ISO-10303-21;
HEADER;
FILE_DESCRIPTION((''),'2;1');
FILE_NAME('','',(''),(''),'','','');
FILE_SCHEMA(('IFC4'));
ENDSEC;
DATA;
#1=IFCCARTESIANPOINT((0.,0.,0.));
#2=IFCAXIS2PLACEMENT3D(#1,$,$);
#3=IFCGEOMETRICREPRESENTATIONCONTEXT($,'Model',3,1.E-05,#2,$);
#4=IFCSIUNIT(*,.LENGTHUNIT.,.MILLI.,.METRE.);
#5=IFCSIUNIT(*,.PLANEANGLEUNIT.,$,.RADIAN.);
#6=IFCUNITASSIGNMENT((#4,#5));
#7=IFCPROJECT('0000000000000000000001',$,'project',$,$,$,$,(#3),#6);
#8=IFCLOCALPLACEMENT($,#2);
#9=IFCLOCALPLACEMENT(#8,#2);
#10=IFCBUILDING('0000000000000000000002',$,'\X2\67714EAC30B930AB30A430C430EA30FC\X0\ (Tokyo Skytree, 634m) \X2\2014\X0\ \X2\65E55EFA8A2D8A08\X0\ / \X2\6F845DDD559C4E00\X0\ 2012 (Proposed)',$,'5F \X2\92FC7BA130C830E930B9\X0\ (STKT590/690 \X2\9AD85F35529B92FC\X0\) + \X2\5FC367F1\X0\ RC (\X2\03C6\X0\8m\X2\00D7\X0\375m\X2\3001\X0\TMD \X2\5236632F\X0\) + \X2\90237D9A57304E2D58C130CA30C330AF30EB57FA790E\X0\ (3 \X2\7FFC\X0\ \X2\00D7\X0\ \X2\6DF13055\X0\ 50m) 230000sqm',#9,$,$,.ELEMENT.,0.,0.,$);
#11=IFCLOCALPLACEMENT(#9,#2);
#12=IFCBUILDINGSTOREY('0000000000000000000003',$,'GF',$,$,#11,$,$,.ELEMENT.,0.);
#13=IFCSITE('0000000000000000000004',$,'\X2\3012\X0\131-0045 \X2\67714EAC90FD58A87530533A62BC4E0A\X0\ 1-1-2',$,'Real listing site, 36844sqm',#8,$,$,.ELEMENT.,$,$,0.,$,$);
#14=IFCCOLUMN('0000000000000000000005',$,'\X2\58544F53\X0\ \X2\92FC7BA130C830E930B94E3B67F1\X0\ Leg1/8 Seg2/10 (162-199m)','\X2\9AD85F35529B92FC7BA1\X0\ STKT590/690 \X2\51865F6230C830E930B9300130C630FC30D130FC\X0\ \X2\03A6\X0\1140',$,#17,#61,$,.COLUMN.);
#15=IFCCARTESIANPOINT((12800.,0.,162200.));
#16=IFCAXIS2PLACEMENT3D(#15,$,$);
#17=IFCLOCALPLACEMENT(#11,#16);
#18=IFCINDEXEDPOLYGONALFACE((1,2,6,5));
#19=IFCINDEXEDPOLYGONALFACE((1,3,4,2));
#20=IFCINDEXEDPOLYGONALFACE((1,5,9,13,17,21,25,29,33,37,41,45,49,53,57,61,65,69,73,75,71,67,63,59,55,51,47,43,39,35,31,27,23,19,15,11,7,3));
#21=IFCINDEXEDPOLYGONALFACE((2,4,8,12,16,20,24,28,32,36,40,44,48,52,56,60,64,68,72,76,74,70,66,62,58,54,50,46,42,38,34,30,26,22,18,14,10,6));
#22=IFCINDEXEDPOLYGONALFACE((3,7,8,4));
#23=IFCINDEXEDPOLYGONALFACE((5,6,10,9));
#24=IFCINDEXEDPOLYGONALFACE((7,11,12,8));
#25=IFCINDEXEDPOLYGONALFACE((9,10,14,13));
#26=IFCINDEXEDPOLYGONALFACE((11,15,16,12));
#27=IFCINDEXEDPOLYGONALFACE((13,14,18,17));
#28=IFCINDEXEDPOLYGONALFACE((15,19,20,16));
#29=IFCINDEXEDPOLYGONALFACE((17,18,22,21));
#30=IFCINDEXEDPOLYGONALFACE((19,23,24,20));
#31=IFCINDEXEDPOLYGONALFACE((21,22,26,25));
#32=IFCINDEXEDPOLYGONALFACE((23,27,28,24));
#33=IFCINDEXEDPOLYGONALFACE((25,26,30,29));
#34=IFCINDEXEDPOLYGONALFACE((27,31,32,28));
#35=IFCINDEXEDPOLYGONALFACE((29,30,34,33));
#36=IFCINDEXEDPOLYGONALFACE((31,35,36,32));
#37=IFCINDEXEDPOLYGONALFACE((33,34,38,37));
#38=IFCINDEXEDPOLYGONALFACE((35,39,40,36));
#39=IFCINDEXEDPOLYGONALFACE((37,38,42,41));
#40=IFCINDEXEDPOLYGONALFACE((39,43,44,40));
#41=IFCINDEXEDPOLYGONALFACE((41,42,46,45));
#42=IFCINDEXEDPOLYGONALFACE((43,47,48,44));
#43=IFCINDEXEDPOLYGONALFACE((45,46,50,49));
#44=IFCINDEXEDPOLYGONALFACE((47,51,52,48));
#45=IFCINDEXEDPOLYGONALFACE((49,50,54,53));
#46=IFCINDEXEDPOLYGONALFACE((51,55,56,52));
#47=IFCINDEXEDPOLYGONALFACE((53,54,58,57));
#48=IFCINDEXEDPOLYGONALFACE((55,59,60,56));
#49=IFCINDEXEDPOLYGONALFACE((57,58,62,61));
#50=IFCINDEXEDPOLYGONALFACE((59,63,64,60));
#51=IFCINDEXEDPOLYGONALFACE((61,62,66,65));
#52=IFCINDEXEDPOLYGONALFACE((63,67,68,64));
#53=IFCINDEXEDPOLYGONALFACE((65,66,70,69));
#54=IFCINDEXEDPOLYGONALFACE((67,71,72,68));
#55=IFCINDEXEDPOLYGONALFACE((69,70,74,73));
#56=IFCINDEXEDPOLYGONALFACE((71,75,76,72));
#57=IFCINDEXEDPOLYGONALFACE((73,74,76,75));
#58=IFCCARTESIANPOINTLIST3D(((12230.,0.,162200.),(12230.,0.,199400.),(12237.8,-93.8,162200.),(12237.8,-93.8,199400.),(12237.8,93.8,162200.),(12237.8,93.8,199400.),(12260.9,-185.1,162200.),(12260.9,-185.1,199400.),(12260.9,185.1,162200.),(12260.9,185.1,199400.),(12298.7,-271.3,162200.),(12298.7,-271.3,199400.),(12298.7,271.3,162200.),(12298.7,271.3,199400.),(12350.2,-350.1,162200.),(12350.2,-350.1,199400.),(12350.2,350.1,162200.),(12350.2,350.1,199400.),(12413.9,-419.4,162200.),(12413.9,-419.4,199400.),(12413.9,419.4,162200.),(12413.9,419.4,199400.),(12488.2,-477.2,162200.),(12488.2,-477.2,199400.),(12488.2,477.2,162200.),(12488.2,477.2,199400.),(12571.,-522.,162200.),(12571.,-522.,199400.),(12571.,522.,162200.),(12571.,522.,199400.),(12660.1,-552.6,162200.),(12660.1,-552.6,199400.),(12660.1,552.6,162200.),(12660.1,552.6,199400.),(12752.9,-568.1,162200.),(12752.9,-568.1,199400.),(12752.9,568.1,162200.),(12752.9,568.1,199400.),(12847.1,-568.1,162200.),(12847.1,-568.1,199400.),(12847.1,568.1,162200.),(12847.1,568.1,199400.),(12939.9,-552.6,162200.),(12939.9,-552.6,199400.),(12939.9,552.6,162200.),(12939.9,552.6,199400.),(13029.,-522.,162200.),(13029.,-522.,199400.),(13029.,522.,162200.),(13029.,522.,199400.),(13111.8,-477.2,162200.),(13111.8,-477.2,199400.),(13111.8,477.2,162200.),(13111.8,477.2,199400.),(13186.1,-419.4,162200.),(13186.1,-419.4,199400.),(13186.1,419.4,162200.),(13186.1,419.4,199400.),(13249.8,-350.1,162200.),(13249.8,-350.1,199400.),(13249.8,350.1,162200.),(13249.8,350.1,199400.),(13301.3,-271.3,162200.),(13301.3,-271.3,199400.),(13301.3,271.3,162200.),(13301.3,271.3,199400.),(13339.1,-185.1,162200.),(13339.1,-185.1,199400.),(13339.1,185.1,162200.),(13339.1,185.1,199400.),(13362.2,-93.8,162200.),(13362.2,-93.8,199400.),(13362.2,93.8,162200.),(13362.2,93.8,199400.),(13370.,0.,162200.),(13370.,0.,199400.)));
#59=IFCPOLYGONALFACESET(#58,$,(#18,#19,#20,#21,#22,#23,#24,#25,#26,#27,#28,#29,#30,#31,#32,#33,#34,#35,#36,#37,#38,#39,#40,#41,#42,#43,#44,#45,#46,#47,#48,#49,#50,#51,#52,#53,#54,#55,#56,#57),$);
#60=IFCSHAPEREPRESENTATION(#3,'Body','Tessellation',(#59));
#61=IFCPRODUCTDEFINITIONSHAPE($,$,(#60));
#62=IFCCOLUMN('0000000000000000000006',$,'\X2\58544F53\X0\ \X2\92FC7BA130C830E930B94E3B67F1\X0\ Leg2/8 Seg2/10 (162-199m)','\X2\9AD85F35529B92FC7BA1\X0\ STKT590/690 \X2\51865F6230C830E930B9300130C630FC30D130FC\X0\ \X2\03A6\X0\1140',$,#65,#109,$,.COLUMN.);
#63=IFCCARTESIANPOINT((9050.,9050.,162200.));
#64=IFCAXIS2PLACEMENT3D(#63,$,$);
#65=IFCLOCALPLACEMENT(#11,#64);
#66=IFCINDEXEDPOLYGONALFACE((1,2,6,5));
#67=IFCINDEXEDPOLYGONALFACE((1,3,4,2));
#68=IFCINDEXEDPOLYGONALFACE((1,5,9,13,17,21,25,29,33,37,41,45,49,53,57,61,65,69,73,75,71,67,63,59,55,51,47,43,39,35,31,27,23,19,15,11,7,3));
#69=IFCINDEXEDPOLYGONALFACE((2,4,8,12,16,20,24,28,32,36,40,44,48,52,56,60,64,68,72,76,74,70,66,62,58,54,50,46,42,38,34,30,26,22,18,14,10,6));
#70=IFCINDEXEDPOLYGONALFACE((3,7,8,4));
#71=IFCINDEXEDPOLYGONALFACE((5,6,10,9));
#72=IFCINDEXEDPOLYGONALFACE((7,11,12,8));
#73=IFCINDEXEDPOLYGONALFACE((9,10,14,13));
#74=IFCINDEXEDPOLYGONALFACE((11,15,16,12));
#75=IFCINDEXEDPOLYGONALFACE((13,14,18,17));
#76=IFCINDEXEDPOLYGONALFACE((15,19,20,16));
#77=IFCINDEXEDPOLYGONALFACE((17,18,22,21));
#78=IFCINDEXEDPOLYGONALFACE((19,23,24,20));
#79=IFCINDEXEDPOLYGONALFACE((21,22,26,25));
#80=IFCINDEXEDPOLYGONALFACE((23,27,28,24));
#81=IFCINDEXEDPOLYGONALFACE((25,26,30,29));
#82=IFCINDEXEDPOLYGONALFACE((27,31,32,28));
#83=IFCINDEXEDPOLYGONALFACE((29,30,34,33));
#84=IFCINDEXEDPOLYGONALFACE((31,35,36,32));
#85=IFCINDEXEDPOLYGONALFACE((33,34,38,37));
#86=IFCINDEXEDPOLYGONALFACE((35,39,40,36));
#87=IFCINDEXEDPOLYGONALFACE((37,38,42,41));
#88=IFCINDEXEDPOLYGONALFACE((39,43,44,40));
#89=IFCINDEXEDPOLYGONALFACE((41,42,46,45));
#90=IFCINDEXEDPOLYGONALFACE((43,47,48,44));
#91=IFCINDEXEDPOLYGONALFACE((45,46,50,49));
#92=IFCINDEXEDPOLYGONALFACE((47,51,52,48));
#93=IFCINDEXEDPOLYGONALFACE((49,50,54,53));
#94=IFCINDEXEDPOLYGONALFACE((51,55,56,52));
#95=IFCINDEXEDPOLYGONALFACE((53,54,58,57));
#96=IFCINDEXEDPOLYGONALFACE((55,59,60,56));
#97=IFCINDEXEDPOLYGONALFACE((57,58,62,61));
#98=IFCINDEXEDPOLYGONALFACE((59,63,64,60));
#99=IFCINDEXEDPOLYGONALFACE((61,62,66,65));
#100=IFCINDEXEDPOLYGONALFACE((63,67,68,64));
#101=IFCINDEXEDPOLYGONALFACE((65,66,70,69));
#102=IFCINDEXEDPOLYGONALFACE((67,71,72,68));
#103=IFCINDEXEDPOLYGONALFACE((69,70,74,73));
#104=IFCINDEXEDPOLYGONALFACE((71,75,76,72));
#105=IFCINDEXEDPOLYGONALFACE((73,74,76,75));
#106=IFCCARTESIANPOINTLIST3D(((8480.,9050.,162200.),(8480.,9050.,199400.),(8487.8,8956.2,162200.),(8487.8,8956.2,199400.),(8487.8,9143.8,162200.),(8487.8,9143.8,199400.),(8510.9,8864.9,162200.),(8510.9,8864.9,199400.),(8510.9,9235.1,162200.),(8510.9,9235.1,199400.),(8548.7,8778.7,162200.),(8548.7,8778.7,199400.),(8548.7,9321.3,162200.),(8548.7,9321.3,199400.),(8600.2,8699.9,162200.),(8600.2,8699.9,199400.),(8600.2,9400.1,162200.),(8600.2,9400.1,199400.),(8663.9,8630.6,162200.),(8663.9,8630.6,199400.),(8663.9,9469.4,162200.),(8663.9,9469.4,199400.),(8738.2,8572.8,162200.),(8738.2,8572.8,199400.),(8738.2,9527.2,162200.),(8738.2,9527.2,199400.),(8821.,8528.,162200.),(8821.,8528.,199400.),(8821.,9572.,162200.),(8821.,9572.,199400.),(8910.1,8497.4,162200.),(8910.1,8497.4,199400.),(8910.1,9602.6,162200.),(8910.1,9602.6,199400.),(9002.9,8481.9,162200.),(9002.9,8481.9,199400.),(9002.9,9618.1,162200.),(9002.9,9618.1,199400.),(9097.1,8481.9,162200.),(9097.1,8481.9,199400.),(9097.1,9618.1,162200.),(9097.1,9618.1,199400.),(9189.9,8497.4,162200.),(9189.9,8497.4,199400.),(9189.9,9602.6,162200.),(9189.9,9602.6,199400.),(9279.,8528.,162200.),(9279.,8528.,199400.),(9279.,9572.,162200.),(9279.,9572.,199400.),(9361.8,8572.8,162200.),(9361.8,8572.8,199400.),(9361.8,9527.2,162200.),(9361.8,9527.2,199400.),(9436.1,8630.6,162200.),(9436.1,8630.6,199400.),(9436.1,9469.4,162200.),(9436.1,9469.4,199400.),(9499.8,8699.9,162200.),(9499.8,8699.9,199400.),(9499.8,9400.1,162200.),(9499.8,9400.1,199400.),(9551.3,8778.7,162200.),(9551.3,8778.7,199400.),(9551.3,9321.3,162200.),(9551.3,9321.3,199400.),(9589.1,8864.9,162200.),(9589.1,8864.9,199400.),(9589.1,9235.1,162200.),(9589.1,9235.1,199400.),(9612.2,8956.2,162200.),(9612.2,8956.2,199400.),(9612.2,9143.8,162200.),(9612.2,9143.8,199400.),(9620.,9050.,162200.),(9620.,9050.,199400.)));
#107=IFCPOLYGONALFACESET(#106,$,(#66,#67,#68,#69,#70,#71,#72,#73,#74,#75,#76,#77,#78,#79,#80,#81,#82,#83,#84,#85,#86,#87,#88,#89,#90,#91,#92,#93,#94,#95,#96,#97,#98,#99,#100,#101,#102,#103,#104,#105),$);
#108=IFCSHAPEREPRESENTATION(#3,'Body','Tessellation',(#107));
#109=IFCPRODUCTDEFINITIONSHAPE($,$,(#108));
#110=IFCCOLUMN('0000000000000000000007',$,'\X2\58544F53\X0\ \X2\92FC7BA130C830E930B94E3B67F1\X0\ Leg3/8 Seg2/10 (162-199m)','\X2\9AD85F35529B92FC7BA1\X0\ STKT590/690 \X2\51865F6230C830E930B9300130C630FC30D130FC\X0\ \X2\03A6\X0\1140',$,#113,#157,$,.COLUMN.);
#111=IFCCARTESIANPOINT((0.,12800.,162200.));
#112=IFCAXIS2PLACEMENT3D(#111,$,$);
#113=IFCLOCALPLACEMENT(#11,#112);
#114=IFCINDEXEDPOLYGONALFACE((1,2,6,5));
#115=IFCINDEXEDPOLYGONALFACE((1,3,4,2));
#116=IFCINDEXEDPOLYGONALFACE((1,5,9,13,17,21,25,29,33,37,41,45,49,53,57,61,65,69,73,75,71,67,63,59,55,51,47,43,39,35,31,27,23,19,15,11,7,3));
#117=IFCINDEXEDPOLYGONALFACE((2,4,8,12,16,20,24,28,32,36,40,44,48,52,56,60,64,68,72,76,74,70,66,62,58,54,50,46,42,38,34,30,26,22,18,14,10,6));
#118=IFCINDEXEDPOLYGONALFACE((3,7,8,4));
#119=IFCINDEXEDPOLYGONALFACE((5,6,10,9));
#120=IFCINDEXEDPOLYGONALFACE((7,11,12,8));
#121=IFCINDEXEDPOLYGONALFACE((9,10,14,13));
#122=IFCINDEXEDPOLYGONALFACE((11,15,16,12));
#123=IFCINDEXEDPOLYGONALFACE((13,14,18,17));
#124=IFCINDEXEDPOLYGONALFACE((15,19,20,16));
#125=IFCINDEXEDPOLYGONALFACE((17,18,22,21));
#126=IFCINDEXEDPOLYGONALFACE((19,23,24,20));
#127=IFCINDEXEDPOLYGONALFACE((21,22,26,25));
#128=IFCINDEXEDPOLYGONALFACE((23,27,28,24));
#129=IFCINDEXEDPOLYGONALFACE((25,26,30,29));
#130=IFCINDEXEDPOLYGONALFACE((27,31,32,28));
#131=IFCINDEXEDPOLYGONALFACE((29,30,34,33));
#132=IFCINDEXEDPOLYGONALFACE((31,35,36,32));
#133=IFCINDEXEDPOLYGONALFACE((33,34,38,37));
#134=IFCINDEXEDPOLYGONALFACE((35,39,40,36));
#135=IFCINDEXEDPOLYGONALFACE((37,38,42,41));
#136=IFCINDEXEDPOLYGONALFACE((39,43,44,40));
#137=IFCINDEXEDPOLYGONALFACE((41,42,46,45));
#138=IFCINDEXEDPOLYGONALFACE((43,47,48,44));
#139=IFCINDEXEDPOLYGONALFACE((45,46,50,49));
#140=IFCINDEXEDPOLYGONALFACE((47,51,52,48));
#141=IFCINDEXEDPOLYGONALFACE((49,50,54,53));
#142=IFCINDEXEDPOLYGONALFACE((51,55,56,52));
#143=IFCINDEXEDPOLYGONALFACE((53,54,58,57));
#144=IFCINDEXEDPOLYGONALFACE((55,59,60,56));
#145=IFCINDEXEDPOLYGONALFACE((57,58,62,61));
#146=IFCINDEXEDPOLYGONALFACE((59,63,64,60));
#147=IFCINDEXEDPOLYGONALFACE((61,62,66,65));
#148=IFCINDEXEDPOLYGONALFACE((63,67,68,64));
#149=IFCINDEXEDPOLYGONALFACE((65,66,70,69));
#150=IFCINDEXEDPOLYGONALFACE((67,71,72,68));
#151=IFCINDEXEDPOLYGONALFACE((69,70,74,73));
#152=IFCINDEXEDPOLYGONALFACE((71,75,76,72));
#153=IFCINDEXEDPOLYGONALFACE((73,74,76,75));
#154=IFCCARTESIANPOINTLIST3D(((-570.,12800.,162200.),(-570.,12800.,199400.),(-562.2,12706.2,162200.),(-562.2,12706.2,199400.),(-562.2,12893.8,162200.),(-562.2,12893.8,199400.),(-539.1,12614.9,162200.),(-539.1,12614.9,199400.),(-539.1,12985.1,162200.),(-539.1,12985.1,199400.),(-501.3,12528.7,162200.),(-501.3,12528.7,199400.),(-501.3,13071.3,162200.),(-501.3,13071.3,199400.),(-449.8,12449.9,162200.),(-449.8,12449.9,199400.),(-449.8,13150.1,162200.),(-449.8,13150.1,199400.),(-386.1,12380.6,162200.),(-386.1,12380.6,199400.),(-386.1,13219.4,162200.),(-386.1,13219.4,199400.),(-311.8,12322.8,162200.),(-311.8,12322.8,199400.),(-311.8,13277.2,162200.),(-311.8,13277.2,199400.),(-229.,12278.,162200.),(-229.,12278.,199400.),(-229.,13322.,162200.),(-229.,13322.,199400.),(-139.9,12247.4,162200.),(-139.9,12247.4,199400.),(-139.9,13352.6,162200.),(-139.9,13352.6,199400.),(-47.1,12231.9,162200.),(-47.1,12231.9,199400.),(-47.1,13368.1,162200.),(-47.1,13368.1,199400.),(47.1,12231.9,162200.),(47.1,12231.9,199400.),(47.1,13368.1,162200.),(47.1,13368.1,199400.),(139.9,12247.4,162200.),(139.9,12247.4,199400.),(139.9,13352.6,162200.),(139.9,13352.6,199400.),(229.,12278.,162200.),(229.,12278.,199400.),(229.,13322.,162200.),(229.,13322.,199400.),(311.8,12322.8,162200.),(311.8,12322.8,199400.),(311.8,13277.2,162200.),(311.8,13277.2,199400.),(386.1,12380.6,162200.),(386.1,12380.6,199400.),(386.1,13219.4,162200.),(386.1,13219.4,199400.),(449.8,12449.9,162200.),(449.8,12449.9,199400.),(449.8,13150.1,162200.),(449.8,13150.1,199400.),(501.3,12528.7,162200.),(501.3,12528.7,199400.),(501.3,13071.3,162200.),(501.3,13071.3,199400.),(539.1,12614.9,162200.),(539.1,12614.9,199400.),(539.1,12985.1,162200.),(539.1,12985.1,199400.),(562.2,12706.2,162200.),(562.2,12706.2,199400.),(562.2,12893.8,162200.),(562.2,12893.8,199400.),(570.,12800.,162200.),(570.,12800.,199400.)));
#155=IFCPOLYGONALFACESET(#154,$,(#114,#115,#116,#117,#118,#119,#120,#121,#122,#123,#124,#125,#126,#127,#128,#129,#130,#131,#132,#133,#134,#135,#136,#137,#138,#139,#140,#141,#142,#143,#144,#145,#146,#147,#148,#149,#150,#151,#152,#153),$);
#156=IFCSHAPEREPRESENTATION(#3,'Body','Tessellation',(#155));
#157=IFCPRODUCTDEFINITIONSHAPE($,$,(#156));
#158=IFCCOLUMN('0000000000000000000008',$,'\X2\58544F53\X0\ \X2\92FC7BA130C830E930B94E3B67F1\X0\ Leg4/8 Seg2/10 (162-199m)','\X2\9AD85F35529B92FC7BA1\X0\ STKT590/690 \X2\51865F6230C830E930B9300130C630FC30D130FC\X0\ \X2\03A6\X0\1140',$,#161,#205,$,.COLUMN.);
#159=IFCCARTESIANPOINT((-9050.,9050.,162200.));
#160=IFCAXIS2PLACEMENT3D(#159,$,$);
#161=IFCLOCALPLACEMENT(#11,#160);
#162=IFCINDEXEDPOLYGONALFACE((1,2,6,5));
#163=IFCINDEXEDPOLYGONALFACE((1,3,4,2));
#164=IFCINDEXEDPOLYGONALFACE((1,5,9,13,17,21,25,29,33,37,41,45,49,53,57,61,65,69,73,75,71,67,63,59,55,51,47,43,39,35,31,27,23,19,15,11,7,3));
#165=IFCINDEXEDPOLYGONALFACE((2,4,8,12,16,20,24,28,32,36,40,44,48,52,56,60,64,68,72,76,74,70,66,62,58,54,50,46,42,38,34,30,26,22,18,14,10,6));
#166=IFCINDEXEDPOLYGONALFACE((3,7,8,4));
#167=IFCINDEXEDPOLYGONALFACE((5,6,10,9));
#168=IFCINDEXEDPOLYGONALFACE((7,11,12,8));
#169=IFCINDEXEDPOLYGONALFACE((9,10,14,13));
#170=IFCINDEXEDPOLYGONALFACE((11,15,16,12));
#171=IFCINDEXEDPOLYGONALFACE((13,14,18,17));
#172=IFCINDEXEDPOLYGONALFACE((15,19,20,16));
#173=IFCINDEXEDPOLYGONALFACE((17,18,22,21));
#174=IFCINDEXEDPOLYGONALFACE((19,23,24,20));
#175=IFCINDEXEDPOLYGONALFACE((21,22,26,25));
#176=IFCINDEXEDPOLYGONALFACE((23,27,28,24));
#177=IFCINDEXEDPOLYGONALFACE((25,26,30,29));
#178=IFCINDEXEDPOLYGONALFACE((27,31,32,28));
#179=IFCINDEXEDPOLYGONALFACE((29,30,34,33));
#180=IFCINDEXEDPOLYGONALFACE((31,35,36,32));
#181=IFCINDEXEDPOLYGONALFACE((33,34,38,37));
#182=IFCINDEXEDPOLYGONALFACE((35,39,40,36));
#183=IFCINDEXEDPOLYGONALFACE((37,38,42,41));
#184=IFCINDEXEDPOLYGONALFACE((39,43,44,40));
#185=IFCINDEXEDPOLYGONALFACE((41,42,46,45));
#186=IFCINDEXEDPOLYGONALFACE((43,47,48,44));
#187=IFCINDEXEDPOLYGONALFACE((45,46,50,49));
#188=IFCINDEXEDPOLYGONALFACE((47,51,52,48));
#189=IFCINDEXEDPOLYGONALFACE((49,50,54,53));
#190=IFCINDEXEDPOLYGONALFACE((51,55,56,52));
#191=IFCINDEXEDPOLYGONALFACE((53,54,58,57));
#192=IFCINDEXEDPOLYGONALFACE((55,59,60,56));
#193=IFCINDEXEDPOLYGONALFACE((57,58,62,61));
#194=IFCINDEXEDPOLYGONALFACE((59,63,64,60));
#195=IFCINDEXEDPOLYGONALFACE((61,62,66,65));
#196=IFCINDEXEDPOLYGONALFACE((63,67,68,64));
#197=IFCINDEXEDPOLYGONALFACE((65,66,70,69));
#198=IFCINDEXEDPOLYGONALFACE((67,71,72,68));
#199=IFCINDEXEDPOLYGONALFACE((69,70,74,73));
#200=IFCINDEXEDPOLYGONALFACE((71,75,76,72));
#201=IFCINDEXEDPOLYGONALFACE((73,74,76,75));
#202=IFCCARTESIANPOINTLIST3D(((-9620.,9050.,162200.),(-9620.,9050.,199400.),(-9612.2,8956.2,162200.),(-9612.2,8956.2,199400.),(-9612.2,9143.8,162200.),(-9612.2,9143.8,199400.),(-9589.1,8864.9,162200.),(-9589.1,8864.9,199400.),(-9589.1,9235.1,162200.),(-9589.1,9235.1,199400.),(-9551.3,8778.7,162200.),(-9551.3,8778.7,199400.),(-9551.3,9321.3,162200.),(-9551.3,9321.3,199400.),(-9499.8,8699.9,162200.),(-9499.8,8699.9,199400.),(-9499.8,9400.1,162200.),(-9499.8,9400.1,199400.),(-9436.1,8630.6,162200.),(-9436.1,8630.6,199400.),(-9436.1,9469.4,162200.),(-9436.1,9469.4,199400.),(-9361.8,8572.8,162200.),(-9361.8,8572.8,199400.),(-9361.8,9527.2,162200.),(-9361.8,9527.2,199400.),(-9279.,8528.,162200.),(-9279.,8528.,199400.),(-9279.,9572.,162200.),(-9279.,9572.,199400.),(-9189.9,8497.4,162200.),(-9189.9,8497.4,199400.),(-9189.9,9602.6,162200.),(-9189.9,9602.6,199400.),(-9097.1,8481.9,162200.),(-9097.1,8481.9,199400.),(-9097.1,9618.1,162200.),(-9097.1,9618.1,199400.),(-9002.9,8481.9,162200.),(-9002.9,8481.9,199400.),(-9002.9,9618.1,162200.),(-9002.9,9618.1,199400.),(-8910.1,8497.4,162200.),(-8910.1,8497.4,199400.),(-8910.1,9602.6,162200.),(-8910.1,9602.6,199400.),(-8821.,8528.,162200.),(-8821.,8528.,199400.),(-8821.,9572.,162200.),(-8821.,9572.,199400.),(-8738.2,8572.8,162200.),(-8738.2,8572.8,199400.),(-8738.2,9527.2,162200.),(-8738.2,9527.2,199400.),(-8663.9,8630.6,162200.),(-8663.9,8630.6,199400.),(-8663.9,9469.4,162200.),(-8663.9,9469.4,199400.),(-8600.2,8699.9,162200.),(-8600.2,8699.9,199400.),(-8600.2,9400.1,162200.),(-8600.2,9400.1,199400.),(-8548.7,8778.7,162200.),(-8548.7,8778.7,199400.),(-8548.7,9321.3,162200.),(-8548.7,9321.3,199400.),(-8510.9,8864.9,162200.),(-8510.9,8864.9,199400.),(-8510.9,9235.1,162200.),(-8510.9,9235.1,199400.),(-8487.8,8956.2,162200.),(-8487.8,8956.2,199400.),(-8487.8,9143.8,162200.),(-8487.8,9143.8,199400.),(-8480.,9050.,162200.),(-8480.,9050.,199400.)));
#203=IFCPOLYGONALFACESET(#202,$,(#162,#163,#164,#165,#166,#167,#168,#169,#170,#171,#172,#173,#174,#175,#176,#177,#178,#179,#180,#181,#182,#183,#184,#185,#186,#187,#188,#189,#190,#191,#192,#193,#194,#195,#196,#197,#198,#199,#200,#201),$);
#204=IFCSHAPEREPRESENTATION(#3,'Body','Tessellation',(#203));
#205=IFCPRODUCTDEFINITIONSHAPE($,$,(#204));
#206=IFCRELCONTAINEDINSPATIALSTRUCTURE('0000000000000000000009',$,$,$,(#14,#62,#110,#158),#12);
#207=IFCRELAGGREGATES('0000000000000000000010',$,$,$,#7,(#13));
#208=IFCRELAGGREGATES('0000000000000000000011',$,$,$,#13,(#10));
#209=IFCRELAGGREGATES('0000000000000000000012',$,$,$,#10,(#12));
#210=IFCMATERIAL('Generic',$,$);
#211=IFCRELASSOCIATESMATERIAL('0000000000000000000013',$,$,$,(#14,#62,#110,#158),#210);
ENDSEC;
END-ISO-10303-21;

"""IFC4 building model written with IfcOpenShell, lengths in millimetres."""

from ifc_helpers import new_model, si_unit, frame, origin, origin_2d, place, context, project, spatial, circle, extrude, material, element, save


model = new_model("IFC4")

# Units and contexts
model_context = context("Model", 3, precision=1e-05, world=origin())
ifc_project = project(units=[si_unit("LENGTHUNIT", "METRE", prefix="MILLI"), si_unit("PLANEANGLEUNIT", "RADIAN")], contexts=[model_context])

# Site, building, storey
site_placement = place(None, origin())
site = spatial("IfcSite", under=ifc_project, at=site_placement, Name="〒131-0045 東京都墨田区押上 1-1-2", ObjectType="Real listing site, 36844sqm", CompositionType="ELEMENT", RefElevation=0.0)
building_placement = place(site_placement, origin())
building = spatial("IfcBuilding", under=site, at=building_placement, Name="東京スカイツリー (Tokyo Skytree, 634m) — 日建設計 / 澄川喜一 2012 (Proposed)", ObjectType="5F 鋼管トラス (STKT590/690 高張力鋼) + 心柱 RC (φ8m×375m、TMD 制振) + 連続地中壁ナックル基礎 (3 翼 × 深さ 50m) 230000sqm", CompositionType="ELEMENT", ElevationOfRefHeight=0.0, ElevationOfTerrain=0.0)
storey_placement = place(building_placement, origin())
storey = spatial("IfcBuildingStorey", under=building, at=storey_placement, Name="GF", CompositionType="ELEMENT", Elevation=0.0)

# Columns
ifc_material = material(Name="Generic")
column_1_placement = place(storey_placement, frame((12800.0, 0.0, 162200.0)))
element("IfcColumn", 1, at=column_1_placement, inside=storey, material=ifc_material, Name="塔体 鋼管トラス主柱 Leg1/8 Seg2/10 (162-199m)", Description="高張力鋼管 STKT590/690 円形トラス、テーパー Φ1140", PredefinedType="COLUMN", context=model_context, shape_type="SweptSolid", body=[
    extrude(circle(Radius=570.0, at=origin_2d()), frame((12800.0, 0.0, 162200.0)), (0.0, 0.0, 1.0), 37200.0),
])
column_2_placement = place(storey_placement, frame((9050.0, 9050.0, 162200.0)))
element("IfcColumn", 2, at=column_2_placement, inside=storey, material=ifc_material, Name="塔体 鋼管トラス主柱 Leg2/8 Seg2/10 (162-199m)", Description="高張力鋼管 STKT590/690 円形トラス、テーパー Φ1140", PredefinedType="COLUMN", context=model_context, shape_type="SweptSolid", body=[
    extrude(circle(Radius=570.0, at=origin_2d()), frame((9050.0, 9050.0, 162200.0)), (0.0, 0.0, 1.0), 37200.0),
])
column_3_placement = place(storey_placement, frame((0.0, 12800.0, 162200.0)))
element("IfcColumn", 3, at=column_3_placement, inside=storey, material=ifc_material, Name="塔体 鋼管トラス主柱 Leg3/8 Seg2/10 (162-199m)", Description="高張力鋼管 STKT590/690 円形トラス、テーパー Φ1140", PredefinedType="COLUMN", context=model_context, shape_type="SweptSolid", body=[
    extrude(circle(Radius=570.0, at=origin_2d()), frame((0.0, 12800.0, 162200.0)), (0.0, 0.0, 1.0), 37200.0),
])
column_4_placement = place(storey_placement, frame((-9050.0, 9050.0, 162200.0)))
element("IfcColumn", 4, at=column_4_placement, inside=storey, material=ifc_material, Name="塔体 鋼管トラス主柱 Leg4/8 Seg2/10 (162-199m)", Description="高張力鋼管 STKT590/690 円形トラス、テーパー Φ1140", PredefinedType="COLUMN", context=model_context, shape_type="SweptSolid", body=[
    extrude(circle(Radius=570.0, at=origin_2d()), frame((-9050.0, 9050.0, 162200.0)), (0.0, 0.0, 1.0), 37200.0),
])

save(model, "model.ifc")
